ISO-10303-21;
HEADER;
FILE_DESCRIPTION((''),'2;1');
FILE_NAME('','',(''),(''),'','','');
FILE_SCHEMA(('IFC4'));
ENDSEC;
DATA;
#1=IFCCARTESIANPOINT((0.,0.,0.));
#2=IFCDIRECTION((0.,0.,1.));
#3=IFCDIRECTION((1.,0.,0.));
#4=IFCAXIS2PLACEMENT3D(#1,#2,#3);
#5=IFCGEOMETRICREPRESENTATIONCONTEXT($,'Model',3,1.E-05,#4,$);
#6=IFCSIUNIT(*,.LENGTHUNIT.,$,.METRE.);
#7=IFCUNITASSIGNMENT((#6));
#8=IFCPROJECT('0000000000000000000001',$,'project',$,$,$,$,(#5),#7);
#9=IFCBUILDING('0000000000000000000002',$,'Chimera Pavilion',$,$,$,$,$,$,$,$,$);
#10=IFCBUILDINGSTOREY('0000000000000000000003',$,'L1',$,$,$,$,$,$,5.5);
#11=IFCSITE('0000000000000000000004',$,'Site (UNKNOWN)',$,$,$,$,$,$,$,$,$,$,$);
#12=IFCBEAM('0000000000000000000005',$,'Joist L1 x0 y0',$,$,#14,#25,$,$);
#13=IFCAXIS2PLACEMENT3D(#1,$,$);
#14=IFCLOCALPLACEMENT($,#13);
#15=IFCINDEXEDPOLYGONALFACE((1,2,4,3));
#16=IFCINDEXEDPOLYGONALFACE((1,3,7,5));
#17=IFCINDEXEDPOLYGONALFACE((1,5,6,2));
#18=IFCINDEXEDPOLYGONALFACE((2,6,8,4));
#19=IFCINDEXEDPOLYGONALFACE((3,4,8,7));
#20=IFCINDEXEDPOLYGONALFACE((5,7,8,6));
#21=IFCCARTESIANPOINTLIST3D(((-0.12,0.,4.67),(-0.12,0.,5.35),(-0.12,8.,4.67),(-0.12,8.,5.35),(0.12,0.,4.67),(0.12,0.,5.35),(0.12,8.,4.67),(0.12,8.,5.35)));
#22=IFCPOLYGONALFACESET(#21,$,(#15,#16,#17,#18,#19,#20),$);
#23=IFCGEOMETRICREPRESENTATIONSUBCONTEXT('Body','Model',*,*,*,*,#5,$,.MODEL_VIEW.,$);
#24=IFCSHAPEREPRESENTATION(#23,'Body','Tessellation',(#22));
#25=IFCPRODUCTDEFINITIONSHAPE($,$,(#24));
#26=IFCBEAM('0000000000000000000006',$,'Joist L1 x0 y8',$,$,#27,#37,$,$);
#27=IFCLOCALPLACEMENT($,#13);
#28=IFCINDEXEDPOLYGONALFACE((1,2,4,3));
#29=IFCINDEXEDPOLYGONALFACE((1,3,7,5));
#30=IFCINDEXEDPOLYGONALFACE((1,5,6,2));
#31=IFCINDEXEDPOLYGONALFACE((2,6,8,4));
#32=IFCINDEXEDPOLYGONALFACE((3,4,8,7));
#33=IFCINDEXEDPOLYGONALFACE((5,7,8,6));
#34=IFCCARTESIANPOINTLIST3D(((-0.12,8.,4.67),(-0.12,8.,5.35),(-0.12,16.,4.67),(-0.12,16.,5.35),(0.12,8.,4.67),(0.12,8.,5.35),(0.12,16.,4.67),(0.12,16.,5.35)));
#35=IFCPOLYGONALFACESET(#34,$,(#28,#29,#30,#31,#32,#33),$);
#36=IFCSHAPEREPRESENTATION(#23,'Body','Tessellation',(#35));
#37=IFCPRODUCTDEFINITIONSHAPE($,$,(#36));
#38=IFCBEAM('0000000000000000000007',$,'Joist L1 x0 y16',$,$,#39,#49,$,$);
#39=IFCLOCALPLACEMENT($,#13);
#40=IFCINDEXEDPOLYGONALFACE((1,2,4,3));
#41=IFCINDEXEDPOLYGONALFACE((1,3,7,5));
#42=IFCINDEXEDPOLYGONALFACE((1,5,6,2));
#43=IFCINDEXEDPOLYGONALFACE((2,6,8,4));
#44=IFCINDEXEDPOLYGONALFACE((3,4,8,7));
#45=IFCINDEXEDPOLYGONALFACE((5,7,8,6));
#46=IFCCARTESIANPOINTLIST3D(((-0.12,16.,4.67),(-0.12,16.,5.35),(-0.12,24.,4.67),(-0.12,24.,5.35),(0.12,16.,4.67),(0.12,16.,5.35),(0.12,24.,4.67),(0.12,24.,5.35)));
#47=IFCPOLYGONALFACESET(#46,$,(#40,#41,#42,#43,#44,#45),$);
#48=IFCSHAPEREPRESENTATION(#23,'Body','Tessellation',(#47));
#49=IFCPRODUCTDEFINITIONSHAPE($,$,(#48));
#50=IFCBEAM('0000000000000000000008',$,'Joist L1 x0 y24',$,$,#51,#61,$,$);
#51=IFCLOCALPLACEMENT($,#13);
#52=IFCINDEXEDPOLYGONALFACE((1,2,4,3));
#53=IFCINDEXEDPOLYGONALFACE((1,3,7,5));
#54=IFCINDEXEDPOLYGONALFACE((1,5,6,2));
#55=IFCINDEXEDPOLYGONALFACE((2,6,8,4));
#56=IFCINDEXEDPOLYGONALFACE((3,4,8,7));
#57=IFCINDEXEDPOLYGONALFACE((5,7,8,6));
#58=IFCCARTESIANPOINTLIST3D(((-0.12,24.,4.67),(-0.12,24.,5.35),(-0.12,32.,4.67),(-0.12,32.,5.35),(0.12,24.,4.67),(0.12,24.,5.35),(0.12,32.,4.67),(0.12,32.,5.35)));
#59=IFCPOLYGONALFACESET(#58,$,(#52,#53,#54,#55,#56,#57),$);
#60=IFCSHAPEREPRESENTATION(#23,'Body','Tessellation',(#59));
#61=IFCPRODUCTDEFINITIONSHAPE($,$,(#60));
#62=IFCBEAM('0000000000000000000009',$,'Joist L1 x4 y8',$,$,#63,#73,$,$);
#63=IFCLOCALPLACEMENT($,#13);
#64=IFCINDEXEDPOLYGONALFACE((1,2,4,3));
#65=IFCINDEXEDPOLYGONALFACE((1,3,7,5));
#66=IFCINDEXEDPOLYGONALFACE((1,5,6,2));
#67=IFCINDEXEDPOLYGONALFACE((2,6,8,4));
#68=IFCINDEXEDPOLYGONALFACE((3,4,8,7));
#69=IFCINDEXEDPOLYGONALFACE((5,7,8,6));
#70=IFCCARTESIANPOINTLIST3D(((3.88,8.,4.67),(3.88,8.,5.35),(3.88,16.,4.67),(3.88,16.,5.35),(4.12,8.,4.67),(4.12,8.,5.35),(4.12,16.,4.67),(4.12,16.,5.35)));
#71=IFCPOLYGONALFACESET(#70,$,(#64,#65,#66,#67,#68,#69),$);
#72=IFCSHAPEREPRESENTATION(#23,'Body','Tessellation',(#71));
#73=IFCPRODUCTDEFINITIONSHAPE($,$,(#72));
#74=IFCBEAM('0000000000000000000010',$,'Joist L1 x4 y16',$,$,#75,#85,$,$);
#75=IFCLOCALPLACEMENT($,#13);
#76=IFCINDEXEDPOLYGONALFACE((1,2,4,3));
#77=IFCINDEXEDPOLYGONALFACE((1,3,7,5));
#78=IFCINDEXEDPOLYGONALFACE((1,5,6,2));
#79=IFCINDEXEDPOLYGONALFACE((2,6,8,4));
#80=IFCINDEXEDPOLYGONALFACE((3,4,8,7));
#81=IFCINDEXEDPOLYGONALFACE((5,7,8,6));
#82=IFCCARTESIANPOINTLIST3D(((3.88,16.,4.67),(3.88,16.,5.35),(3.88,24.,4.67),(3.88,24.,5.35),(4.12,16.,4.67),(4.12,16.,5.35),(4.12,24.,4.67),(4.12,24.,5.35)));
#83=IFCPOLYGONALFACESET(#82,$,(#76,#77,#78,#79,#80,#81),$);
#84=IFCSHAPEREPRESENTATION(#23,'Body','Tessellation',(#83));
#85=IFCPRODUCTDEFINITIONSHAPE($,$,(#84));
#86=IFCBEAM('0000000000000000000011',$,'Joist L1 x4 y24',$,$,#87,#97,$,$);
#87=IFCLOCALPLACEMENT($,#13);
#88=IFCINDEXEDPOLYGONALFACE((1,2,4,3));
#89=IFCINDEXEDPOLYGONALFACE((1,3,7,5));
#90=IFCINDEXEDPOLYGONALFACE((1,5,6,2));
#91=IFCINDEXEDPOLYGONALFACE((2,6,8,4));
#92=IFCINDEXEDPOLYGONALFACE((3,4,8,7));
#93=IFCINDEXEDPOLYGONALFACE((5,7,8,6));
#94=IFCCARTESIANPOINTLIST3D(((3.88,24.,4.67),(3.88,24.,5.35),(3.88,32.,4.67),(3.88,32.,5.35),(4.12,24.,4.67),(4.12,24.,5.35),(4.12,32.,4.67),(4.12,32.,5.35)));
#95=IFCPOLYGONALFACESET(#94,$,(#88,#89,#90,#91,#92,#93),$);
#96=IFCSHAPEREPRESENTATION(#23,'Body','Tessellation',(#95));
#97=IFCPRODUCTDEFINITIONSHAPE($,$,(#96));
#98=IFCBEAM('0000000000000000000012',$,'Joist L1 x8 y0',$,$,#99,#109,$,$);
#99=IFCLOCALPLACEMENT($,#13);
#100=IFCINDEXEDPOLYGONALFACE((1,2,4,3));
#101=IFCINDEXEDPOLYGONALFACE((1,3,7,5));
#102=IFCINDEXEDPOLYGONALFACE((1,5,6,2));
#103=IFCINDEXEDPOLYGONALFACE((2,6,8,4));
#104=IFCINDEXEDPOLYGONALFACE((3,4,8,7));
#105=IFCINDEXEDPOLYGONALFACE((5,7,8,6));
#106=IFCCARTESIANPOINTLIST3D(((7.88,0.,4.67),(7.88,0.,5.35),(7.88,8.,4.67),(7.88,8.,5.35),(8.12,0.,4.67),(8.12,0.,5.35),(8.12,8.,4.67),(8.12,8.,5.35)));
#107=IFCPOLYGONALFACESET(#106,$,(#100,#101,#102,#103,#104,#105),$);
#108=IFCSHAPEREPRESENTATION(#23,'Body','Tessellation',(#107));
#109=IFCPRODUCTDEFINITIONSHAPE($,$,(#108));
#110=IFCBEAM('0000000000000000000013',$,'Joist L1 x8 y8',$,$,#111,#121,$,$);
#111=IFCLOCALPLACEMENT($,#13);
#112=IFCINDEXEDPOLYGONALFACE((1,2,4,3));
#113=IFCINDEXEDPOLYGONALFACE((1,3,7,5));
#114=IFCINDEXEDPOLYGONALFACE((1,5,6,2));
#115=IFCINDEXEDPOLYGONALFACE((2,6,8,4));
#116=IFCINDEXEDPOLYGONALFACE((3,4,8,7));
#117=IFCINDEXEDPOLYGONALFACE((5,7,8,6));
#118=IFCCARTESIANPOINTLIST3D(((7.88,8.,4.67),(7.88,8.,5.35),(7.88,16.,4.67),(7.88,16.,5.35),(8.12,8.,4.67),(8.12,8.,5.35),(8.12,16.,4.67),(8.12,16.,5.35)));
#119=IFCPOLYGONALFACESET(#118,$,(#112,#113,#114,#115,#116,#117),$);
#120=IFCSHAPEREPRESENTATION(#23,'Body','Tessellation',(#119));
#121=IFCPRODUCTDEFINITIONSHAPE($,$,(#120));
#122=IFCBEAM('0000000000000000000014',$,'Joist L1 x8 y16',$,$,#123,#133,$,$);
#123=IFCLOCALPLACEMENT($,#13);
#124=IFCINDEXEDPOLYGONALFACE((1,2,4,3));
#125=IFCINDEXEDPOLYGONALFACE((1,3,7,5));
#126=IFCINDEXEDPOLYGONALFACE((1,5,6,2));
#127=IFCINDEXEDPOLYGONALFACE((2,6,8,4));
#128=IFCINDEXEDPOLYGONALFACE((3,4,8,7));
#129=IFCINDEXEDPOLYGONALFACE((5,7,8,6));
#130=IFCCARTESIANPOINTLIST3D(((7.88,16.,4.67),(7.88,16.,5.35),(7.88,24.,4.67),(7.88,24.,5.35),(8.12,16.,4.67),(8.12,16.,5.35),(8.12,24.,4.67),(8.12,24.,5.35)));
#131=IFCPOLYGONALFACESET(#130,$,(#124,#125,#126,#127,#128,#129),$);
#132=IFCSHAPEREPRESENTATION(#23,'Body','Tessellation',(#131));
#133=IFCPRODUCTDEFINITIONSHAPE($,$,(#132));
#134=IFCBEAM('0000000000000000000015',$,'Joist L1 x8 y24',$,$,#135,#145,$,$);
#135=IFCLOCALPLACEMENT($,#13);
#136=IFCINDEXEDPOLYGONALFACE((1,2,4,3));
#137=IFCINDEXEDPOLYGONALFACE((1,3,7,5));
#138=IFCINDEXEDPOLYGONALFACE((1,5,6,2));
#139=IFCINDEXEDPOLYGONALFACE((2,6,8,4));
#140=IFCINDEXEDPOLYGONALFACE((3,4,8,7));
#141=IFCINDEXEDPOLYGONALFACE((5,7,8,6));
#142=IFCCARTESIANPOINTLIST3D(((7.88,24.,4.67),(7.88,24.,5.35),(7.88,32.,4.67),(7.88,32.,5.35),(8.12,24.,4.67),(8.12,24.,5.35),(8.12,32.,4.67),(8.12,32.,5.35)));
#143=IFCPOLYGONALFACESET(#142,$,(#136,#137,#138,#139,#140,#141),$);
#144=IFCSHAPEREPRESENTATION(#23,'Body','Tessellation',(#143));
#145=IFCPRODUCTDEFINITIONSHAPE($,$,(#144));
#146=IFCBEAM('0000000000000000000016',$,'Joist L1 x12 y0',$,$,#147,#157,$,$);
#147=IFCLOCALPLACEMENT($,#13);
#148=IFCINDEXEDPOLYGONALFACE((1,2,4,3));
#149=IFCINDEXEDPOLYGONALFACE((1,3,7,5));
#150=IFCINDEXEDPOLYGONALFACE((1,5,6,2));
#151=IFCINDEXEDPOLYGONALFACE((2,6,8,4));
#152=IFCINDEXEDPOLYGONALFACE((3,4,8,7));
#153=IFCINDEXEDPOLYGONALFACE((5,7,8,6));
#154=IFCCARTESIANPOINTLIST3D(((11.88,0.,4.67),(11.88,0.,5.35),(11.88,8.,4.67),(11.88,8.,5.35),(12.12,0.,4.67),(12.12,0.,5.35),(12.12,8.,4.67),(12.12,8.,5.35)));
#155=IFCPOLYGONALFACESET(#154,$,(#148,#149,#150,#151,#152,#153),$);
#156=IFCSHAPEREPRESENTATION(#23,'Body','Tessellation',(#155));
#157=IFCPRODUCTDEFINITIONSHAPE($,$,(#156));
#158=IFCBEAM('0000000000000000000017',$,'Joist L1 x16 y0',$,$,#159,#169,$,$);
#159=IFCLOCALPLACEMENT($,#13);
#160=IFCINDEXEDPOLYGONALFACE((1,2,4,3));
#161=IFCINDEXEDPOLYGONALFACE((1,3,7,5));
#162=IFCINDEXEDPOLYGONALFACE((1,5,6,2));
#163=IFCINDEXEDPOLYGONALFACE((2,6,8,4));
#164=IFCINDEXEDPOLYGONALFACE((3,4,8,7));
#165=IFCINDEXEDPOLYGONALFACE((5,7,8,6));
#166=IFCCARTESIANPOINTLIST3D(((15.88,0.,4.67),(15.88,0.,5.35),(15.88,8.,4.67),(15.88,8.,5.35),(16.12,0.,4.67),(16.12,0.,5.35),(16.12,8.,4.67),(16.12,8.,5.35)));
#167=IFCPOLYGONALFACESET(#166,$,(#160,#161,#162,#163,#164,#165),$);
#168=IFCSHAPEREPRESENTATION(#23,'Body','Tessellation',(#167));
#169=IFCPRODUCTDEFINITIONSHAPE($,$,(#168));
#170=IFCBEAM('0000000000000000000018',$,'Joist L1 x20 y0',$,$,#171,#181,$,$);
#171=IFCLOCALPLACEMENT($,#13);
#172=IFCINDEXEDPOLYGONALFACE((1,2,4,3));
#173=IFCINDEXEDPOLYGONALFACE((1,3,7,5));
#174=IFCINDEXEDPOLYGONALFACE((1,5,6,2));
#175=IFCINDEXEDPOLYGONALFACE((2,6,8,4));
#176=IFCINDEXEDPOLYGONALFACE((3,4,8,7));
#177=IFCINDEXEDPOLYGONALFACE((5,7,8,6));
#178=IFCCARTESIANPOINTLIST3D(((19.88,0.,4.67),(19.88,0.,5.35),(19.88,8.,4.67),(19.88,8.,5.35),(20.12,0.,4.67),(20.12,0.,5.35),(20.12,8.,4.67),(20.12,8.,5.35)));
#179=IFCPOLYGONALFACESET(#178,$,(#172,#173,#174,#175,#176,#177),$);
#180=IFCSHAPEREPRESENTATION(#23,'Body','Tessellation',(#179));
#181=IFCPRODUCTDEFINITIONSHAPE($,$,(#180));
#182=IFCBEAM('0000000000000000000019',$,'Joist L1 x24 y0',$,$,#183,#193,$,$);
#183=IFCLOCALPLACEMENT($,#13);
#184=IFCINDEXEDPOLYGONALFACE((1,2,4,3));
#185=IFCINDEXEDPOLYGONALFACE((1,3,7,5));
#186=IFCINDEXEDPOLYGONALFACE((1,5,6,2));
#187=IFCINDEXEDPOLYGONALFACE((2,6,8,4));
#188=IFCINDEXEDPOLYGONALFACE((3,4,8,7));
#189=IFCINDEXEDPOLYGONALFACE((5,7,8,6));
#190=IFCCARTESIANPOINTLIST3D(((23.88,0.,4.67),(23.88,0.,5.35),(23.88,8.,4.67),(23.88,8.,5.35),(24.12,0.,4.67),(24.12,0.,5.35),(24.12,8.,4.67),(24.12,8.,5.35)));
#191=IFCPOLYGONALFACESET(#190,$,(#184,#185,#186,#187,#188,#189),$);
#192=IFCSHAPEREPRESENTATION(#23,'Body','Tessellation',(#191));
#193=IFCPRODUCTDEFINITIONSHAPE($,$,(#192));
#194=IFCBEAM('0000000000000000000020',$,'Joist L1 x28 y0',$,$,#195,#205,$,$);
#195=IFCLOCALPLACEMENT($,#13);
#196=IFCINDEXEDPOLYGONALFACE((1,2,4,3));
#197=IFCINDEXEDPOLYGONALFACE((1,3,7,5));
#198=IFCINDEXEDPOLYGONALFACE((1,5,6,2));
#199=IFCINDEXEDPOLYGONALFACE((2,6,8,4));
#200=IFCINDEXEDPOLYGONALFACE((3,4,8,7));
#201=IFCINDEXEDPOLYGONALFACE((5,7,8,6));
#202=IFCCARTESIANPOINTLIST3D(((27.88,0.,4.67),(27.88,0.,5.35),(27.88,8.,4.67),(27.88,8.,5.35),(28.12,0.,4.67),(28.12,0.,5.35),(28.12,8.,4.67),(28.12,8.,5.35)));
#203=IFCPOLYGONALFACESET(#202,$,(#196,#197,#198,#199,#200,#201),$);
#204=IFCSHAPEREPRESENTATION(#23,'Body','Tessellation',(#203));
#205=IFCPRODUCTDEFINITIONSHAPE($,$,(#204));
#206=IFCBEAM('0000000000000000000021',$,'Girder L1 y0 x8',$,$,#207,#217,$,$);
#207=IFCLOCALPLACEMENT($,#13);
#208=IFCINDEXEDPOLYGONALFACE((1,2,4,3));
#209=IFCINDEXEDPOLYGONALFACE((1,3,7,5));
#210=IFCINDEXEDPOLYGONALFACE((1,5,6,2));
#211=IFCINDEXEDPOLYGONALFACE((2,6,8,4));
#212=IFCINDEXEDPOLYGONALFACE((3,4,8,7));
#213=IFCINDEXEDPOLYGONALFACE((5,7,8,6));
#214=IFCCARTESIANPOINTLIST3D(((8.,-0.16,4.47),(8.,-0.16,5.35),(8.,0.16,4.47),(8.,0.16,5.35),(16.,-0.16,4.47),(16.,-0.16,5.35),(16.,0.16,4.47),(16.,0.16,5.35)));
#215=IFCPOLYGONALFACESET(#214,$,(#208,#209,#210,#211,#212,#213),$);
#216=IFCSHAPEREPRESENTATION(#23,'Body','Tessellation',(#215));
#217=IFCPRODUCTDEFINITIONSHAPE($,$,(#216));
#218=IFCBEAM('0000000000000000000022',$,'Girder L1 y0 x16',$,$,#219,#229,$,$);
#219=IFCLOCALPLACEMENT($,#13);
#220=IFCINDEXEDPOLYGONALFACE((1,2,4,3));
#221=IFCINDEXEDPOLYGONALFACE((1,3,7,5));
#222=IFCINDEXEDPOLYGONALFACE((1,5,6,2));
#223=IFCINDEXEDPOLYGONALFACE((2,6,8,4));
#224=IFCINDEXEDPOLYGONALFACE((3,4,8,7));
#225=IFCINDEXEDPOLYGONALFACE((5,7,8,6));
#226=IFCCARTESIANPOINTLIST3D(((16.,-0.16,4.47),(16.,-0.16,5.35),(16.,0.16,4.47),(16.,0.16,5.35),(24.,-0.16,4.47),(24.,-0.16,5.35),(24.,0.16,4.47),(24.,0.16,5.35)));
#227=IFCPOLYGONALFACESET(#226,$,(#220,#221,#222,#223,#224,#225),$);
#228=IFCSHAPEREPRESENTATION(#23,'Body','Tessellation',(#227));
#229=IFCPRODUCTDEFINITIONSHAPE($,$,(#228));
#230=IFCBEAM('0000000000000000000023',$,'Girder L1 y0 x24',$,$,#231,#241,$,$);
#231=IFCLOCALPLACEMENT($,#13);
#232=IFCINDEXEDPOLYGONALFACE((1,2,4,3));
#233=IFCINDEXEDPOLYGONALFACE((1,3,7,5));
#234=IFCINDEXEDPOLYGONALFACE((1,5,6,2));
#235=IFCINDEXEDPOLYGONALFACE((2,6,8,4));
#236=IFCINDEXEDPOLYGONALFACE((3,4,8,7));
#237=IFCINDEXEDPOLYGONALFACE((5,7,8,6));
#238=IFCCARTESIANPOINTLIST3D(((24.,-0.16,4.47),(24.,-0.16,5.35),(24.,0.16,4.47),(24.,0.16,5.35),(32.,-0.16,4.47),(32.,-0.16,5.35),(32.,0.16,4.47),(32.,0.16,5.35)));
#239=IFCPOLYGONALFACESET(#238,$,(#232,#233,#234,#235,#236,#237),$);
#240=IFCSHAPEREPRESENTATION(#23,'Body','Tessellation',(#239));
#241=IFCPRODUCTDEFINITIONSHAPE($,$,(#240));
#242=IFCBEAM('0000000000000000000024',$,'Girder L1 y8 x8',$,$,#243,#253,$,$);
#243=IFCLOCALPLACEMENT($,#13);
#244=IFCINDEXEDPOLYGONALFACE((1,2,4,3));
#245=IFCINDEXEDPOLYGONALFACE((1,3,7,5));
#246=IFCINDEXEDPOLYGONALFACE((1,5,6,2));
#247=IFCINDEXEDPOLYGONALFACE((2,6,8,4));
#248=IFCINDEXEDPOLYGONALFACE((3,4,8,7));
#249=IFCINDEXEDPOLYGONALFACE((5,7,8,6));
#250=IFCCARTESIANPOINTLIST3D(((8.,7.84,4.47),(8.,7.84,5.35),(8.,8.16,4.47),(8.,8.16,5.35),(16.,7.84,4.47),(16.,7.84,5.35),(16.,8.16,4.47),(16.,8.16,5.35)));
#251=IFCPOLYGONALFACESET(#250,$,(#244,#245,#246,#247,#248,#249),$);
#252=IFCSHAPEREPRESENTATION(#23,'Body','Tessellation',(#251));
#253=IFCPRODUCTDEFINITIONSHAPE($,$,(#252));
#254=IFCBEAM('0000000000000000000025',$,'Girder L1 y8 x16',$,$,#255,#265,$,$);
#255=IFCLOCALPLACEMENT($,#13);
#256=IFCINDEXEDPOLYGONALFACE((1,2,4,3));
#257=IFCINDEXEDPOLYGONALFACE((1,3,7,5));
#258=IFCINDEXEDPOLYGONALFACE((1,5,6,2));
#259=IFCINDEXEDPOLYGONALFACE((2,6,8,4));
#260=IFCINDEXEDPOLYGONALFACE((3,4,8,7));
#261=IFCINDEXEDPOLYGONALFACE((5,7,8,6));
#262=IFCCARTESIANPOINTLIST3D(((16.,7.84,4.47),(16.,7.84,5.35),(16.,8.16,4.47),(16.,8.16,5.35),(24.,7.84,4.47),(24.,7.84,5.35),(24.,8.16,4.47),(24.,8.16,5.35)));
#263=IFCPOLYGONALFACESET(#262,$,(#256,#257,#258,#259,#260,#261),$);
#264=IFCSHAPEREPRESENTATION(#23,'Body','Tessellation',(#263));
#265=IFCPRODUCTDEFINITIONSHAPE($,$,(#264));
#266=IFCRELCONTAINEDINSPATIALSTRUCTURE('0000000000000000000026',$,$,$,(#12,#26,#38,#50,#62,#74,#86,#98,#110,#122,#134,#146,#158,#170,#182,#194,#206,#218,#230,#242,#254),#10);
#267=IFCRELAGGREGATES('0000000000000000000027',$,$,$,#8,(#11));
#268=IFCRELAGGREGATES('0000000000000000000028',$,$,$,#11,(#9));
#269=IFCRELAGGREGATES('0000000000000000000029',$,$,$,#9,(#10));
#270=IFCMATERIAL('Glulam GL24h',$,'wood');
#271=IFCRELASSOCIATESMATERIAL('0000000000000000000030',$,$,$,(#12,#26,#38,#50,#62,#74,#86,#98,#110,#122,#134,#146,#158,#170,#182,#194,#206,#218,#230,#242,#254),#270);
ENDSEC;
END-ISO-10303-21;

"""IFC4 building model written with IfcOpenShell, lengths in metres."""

from ifc_helpers import new_model, si_unit, frame, origin_with_axes, place, context, subcontext, project, spatial, rectangle, extrude, material, element, save


model = new_model("IFC4")

# Units and contexts
model_context = context("Model", 3, precision=1e-05, world=origin_with_axes())
body_context = subcontext(model_context, "Body", "Model", "MODEL_VIEW")
ifc_project = project(units=[si_unit("LENGTHUNIT", "METRE")], contexts=[model_context])

# Site, building, storey
site = spatial("IfcSite", under=ifc_project, Name="Site (UNKNOWN)")
building = spatial("IfcBuilding", under=site, Name="Chimera Pavilion")
storey = spatial("IfcBuildingStorey", under=building, Name="L1", Elevation=5.5)

# Beams
ifc_material_1 = material(Name="Glulam GL24h", Category="wood")
for number, where, z_axis, x_axis, name in (
    (1, (0.0, 0.0, 5.01), (0.0, 1.0, 0.0), (1.0, 0.0, 0.0), "Joist L1 x0 y0"),
    (2, (0.0, 8.0, 5.01), (0.0, 1.0, 0.0), (1.0, 0.0, 0.0), "Joist L1 x0 y8"),
    (3, (0.0, 16.0, 5.01), (0.0, 1.0, 0.0), (1.0, 0.0, 0.0), "Joist L1 x0 y16"),
    (4, (0.0, 24.0, 5.01), (0.0, 1.0, 0.0), (1.0, 0.0, 0.0), "Joist L1 x0 y24"),
    (5, (4.0, 8.0, 5.01), (0.0, 1.0, 0.0), (1.0, 0.0, 0.0), "Joist L1 x4 y8"),
    (6, (4.0, 16.0, 5.01), (0.0, 1.0, 0.0), (1.0, 0.0, 0.0), "Joist L1 x4 y16"),
    (7, (4.0, 24.0, 5.01), (0.0, 1.0, 0.0), (1.0, 0.0, 0.0), "Joist L1 x4 y24"),
    (8, (8.0, 0.0, 5.01), (0.0, 1.0, 0.0), (1.0, 0.0, 0.0), "Joist L1 x8 y0"),
    (9, (8.0, 8.0, 5.01), (0.0, 1.0, 0.0), (1.0, 0.0, 0.0), "Joist L1 x8 y8"),
    (10, (8.0, 16.0, 5.01), (0.0, 1.0, 0.0), (1.0, 0.0, 0.0), "Joist L1 x8 y16"),
    (11, (8.0, 24.0, 5.01), (0.0, 1.0, 0.0), (1.0, 0.0, 0.0), "Joist L1 x8 y24"),
    (12, (12.0, 0.0, 5.01), (0.0, 1.0, 0.0), (1.0, 0.0, 0.0), "Joist L1 x12 y0"),
    (13, (16.0, 0.0, 5.01), (0.0, 1.0, 0.0), (1.0, 0.0, 0.0), "Joist L1 x16 y0"),
    (14, (20.0, 0.0, 5.01), (0.0, 1.0, 0.0), (1.0, 0.0, 0.0), "Joist L1 x20 y0"),
    (15, (24.0, 0.0, 5.01), (0.0, 1.0, 0.0), (1.0, 0.0, 0.0), "Joist L1 x24 y0"),
    (16, (28.0, 0.0, 5.01), (0.0, 1.0, 0.0), (1.0, 0.0, 0.0), "Joist L1 x28 y0"),
):
    element("IfcBeam", number, at=place(None, frame(where, z_axis=z_axis, x_axis=x_axis)), inside=storey, material=ifc_material_1, Name=name, context=body_context, shape_type="SweptSolid", body=[
        extrude(rectangle(XDim=0.24, YDim=0.68), origin_with_axes(), (0.0, 0.0, 1.0), 8.0),
    ])
for number, where, z_axis, x_axis, name in (
    (17, (8.0, 0.0, 4.91), (1.0, 0.0, 0.0), (0.0, -1.0, 0.0), "Girder L1 y0 x8"),
    (18, (16.0, 0.0, 4.91), (1.0, 0.0, 0.0), (0.0, -1.0, 0.0), "Girder L1 y0 x16"),
    (19, (24.0, 0.0, 4.91), (1.0, 0.0, 0.0), (0.0, -1.0, 0.0), "Girder L1 y0 x24"),
    (20, (8.0, 8.0, 4.91), (1.0, 0.0, 0.0), (0.0, -1.0, 0.0), "Girder L1 y8 x8"),
    (21, (16.0, 8.0, 4.91), (1.0, 0.0, 0.0), (0.0, -1.0, 0.0), "Girder L1 y8 x16"),
):
    element("IfcBeam", number, at=place(None, frame(where, z_axis=z_axis, x_axis=x_axis)), inside=storey, material=ifc_material_1, Name=name, context=body_context, shape_type="SweptSolid", body=[
        extrude(rectangle(XDim=0.32, YDim=0.88), origin_with_axes(), (0.0, 0.0, 1.0), 8.0),
    ])

save(model, "model.ifc")
